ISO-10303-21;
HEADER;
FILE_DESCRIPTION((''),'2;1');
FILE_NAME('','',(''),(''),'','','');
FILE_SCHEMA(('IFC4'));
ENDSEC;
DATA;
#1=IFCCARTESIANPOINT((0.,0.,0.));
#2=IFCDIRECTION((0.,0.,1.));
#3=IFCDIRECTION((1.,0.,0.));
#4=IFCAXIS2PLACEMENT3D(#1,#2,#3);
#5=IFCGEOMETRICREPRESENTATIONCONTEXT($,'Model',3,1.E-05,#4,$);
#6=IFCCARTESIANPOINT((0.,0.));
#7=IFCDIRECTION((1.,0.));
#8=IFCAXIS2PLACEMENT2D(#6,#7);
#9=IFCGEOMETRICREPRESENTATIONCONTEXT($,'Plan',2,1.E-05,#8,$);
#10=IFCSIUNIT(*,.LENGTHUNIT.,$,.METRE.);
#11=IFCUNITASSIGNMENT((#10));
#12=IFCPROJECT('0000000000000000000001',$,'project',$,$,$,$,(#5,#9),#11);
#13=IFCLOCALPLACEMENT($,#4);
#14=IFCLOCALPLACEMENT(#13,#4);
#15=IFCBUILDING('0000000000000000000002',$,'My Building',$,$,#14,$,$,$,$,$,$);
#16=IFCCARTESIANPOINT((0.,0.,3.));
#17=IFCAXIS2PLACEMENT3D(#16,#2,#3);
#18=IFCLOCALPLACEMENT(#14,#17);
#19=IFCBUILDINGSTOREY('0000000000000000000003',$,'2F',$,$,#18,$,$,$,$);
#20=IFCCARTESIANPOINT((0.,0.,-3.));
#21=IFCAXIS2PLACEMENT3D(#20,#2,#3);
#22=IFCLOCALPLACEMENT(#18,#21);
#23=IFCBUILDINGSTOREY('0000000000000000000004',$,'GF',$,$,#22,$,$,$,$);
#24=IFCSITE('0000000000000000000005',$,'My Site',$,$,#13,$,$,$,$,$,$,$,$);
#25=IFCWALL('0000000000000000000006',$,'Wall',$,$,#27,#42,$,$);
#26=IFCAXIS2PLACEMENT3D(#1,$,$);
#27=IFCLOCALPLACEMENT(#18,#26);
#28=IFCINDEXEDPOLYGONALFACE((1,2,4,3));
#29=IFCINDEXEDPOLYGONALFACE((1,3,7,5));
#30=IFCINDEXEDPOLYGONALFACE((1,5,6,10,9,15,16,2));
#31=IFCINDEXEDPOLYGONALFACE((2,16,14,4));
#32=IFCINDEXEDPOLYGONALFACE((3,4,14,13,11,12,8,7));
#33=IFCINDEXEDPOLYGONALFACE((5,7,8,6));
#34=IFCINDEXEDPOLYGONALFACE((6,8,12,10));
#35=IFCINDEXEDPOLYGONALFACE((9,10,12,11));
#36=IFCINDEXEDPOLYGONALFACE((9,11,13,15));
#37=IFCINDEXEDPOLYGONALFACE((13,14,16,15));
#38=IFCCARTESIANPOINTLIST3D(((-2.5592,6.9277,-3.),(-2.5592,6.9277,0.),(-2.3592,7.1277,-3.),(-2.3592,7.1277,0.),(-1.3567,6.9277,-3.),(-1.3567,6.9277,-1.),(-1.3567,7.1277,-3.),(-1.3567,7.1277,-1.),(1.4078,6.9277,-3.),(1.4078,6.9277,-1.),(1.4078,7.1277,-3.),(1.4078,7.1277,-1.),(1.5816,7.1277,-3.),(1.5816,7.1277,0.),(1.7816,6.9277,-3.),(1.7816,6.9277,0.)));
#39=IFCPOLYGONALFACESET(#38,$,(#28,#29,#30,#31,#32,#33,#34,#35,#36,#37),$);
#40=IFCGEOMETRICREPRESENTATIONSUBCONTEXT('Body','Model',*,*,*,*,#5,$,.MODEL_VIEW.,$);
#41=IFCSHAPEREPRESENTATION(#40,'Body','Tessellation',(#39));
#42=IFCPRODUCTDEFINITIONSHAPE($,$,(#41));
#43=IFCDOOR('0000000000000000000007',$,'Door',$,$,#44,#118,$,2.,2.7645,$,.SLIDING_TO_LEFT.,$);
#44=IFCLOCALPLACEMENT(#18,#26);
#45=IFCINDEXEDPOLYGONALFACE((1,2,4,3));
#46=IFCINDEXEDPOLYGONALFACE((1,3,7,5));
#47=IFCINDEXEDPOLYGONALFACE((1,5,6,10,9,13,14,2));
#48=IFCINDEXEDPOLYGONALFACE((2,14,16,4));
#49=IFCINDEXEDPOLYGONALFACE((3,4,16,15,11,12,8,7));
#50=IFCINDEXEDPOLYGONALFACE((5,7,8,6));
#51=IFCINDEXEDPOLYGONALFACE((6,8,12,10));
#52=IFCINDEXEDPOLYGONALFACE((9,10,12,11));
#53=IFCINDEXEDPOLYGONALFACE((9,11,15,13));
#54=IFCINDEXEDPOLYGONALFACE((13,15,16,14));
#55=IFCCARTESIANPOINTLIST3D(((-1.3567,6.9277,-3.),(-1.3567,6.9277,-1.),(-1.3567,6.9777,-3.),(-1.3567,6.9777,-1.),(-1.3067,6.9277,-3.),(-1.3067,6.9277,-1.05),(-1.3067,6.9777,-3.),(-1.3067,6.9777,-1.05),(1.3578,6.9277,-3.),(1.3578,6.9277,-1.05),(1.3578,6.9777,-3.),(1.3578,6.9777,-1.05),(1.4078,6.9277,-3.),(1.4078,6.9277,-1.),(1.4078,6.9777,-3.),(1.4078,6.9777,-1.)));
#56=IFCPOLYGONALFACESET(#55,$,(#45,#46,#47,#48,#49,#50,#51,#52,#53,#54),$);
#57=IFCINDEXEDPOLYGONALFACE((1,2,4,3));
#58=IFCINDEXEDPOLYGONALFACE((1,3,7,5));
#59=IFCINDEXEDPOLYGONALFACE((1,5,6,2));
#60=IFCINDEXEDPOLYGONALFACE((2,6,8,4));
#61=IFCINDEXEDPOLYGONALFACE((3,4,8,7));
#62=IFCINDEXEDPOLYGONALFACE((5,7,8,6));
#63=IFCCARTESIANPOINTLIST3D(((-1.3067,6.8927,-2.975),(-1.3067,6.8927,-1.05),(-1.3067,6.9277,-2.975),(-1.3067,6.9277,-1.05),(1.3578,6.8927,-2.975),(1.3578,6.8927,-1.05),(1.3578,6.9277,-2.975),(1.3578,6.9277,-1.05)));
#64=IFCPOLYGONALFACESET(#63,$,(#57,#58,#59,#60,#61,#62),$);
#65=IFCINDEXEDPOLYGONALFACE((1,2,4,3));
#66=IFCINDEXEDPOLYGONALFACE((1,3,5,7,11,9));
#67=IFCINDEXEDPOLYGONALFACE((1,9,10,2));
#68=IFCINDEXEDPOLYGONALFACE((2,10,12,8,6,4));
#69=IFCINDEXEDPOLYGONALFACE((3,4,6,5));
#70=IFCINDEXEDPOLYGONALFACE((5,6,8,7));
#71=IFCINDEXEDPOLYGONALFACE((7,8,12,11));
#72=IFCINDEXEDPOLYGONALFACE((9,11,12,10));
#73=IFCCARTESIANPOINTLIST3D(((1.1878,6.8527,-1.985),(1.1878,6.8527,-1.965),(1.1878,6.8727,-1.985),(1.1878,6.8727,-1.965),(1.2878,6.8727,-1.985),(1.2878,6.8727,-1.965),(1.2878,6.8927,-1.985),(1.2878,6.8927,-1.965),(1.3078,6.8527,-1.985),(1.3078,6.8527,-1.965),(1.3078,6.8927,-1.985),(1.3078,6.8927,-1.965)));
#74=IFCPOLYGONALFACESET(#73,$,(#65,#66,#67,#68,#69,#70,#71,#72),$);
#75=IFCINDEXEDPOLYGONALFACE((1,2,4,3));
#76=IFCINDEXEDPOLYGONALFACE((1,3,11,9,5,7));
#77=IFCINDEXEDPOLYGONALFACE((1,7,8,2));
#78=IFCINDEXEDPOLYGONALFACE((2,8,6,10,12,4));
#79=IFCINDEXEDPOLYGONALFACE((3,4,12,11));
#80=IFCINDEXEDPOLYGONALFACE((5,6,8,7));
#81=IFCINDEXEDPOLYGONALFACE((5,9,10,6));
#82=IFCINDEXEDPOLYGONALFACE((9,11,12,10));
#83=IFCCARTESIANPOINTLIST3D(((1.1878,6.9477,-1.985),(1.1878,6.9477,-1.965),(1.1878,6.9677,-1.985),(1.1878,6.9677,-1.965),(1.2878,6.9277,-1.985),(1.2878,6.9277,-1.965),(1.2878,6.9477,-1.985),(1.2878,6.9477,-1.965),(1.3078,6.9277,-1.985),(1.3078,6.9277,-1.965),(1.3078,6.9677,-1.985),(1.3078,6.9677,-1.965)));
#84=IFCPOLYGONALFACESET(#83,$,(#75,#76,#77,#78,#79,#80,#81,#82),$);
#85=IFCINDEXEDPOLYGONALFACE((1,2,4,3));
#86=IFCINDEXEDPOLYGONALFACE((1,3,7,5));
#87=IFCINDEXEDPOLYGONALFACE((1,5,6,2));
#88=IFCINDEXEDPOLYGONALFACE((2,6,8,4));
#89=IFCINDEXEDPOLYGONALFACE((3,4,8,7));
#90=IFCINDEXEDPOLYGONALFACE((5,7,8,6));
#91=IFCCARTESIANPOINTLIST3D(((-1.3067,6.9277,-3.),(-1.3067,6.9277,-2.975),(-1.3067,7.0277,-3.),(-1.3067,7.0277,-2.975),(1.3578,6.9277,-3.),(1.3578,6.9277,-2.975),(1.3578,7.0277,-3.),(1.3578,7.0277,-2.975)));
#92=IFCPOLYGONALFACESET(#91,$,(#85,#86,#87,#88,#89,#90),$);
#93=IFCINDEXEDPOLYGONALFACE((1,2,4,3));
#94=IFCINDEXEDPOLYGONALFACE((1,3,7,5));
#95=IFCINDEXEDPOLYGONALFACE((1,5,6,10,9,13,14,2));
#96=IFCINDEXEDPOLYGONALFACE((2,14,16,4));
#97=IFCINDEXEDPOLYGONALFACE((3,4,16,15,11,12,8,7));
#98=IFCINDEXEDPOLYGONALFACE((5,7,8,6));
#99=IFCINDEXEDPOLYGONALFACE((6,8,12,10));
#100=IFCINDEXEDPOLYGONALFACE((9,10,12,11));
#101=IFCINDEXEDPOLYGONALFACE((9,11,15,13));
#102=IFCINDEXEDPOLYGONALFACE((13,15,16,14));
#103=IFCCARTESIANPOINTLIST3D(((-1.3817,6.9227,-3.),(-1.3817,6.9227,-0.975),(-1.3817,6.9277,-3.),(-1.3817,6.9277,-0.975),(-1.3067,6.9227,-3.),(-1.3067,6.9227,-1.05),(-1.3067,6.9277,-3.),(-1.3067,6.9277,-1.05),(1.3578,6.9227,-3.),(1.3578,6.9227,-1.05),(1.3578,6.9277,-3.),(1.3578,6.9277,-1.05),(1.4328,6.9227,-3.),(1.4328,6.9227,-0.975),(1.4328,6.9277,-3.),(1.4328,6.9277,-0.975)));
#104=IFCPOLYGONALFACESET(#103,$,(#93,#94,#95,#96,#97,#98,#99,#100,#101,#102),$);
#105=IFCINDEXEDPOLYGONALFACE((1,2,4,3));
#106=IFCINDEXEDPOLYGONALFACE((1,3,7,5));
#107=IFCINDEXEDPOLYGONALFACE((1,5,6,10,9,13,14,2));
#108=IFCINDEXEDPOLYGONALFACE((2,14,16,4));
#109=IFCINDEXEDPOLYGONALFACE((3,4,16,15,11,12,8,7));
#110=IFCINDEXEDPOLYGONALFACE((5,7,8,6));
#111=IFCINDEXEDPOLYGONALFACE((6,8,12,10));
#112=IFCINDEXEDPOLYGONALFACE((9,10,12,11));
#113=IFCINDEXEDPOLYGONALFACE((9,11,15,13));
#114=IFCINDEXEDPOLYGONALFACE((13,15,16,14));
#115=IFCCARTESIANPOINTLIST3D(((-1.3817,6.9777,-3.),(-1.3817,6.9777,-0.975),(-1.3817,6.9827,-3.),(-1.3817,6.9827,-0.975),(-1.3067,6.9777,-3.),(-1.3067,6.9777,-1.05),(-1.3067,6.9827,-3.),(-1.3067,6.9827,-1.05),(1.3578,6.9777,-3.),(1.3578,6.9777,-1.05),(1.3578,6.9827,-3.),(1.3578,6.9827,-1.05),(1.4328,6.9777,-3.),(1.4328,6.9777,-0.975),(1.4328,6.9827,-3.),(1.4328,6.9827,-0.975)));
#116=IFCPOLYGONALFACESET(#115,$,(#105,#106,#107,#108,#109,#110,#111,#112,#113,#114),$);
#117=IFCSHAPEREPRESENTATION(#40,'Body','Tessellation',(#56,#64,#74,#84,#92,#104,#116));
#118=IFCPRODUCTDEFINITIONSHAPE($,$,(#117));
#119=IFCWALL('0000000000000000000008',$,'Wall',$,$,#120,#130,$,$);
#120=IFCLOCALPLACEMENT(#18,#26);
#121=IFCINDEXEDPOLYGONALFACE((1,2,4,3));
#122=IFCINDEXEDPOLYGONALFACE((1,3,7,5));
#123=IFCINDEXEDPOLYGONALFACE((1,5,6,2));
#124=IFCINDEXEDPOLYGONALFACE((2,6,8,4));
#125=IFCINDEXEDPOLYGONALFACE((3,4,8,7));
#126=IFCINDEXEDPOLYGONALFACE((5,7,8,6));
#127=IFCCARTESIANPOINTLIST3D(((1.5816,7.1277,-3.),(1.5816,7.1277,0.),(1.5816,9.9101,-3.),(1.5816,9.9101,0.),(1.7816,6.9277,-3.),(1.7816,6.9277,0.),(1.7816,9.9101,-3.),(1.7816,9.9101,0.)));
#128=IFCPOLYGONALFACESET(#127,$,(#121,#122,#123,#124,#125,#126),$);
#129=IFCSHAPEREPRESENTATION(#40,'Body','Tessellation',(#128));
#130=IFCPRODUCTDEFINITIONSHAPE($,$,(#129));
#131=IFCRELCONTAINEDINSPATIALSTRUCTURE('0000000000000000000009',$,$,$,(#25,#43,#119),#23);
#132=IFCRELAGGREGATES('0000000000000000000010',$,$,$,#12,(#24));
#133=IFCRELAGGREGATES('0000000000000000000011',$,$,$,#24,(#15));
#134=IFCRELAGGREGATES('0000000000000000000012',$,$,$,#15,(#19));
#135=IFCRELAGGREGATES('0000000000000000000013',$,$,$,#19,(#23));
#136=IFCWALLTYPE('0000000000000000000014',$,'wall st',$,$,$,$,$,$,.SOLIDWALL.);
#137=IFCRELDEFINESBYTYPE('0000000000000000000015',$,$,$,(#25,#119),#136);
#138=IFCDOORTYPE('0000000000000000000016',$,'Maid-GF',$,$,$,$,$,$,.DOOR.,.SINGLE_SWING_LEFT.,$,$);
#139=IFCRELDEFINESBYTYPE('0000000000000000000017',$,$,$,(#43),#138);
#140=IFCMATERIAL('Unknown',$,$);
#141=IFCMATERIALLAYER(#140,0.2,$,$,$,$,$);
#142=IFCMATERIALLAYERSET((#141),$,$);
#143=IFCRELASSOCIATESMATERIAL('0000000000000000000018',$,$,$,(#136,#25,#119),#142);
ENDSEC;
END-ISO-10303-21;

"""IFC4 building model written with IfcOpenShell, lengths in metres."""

from ifc_helpers import new_model, entity, si_unit, frame, origin_with_axes, origin_2d_with_axis, place, context, subcontext, project, spatial, line, indexed_curve, outline, extrude, shape, source, transform, mapped, material, layer, layer_set, layer_usage, type_object, type_shapes, element, fill, save


model = new_model("IFC4")

# Units and contexts
model_context = context("Model", 3, precision=1e-05, world=origin_with_axes())
plan_context = context("Plan", 2, precision=1e-05, world=origin_2d_with_axis())
body_context_1 = subcontext(model_context, "Body", "Model", "MODEL_VIEW")
body_context_2 = subcontext(plan_context, "Body", "Plan", "PLAN_VIEW")
ifc_project = project(units=[si_unit("LENGTHUNIT", "METRE")], contexts=[model_context, plan_context])

# Site, building, storeys
site_placement = place(None, origin_with_axes())
site = spatial("IfcSite", under=ifc_project, at=site_placement, Name="My Site")
building_placement = place(site_placement, origin_with_axes())
building = spatial("IfcBuilding", under=site, at=building_placement, Name="My Building")
storey_1_placement = place(building_placement, frame((0.0, 0.0, 3.0), z_axis=(0.0, 0.0, 1.0), x_axis=(1.0, 0.0, 0.0)))
storey_1 = spatial("IfcBuildingStorey", under=building, at=storey_1_placement, Name="2F")
storey_2_placement = place(storey_1_placement, frame((0.0, 0.0, -3.0), z_axis=(0.0, 0.0, 1.0), x_axis=(1.0, 0.0, 0.0)))
storey_2 = spatial("IfcBuildingStorey", under=storey_1, at=storey_2_placement, Name="GF")

# Shared definitions
ifc_material = material(Name="Unknown")

# Shared definitions
ifc_layer = layer(ifc_material, 0.2)
ifc_layer_set = layer_set([ifc_layer])
wall_type = type_object("IfcWallType", Name="wall st", PredefinedType="SOLIDWALL", material=ifc_layer_set)

# Wall, opening, door
ifc_layer_usage_1 = layer_usage(ifc_layer_set, "AXIS2", "POSITIVE", 0.0)
wall_1_placement = place(storey_2_placement, frame((-2.5592, 6.9277, 0.0), z_axis=(0.0, 0.0, 1.0), x_axis=(1.0, 0.0, 0.0)))
wall_1 = element("IfcWall", 1, at=wall_1_placement, inside=storey_2, type_object=wall_type, material=ifc_layer_usage_1, Name="Wall", context=body_context_1, shape_type="SweptSolid", body=[
    extrude(outline(indexed_curve([(0.0, 0.0), (0.2, 0.2), (4.1408, 0.2), (4.3408, 0.0)], segments=[line(1, 2, 3, 4, 1)])), origin_with_axes(), (0.0, 0.0, 1.0), 3.0),
])
shared_shape_1 = source(origin_with_axes(), body_context_1, "Body", "SweptSolid", [
    extrude(outline(indexed_curve([(0.0, 0.0), (2.7645, 0.0), (2.7645, 2.0), (0.0, 2.0)], segments=[line(1, 2, 3, 4, 1)])), frame((0.0, -0.6, 0.0), z_axis=(0.0, -1.0, 0.0), x_axis=(1.0, 0.0, 0.0)), (0.0, 0.0, -1.0), 1.2),
])
opening_1_placement = place(wall_1_placement, frame((1.2026, 0.0, 0.0), z_axis=(0.0, 0.0, 1.0), x_axis=(1.0, 0.0, 0.0)))
opening_1 = element("IfcOpeningElement", 2, at=opening_1_placement, cuts=wall_1, PredefinedType="OPENING", context=body_context_1, shape_type="MappedRepresentation", body=[
    mapped(shared_shape_1, transform((0.0, 0.0, 0.0), x_axis=(1.0, 0.0, 0.0), y_axis=(0.0, 1.0, 0.0), z_axis=(0.0, 0.0, 1.0), scale=1.0)),
])
door_type_1 = type_object("IfcDoorType", Name="Maid-GF", OperationType="SINGLE_SWING_LEFT", PredefinedType="DOOR")
shared_shape_2 = source(origin_with_axes(), body_context_1, "Body", "SweptSolid", [
    extrude(outline(indexed_curve([(0.0, 0.0), (0.0, 2.0), (2.7645, 2.0), (2.7645, 0.0), (2.7145, 0.0), (2.7145, 1.95), (0.05, 1.95), (0.05, 0.0)], segments=[line(1, 2, 3, 4, 5, 6, 7, 8, 1)])), frame((0.0, 0.0, 0.0), z_axis=(0.0, -1.0, 0.0), x_axis=(1.0, 0.0, 0.0)), (0.0, 0.0, -1.0), 0.05),
    extrude(outline(indexed_curve([(0.0, 0.0), (2.6645, 0.0), (2.6645, 0.035), (0.0, 0.035)], segments=[line(1, 2, 3, 4, 1)])), frame((0.05, -0.035, 0.025), z_axis=(0.0, 0.0, 1.0), x_axis=(1.0, 0.0, 0.0)), (0.0, 0.0, 1.0), 1.925),
    extrude(outline(indexed_curve([(0.0, 0.0), (0.0, -0.04), (-0.12, -0.04), (-0.12, -0.02), (-0.02, -0.02), (-0.02, 0.0)], segments=[line(1, 2, 3, 4, 5, 6, 1)])), frame((2.6645, -0.035, 1.015), z_axis=(0.0, 0.0, 1.0), x_axis=(1.0, 0.0, 0.0)), (0.0, 0.0, 1.0), 0.02),
    extrude(outline(indexed_curve([(0.0, 0.0), (0.0, 0.04), (-0.12, 0.04), (-0.12, 0.02), (-0.02, 0.02), (-0.02, 0.0)], segments=[line(1, 2, 3, 4, 5, 6, 1)])), frame((2.6645, 0.0, 1.015), z_axis=(0.0, 0.0, 1.0), x_axis=(1.0, 0.0, 0.0)), (0.0, 0.0, 1.0), 0.02),
    extrude(outline(indexed_curve([(0.0, 0.0), (2.6645, 0.0), (2.6645, 0.1), (0.0, 0.1)], segments=[line(1, 2, 3, 4, 1)])), frame((0.05, 0.0, 0.0), z_axis=(0.0, 0.0, 1.0), x_axis=(1.0, 0.0, 0.0)), (0.0, 0.0, 1.0), 0.025),
    extrude(outline(indexed_curve([(0.0, 0.0), (0.0, 2.025), (2.8145, 2.025), (2.8145, 0.0), (2.7395, 0.0), (2.7395, 1.95), (0.075, 1.95), (0.075, 0.0)], segments=[line(1, 2, 3, 4, 5, 6, 7, 8, 1)])), frame((-0.025, -0.005, 0.0), z_axis=(0.0, -1.0, 0.0), x_axis=(1.0, 0.0, 0.0)), (0.0, 0.0, -1.0), 0.005),
    extrude(outline(indexed_curve([(0.0, 0.0), (0.0, 2.025), (2.8145, 2.025), (2.8145, 0.0), (2.7395, 0.0), (2.7395, 1.95), (0.075, 1.95), (0.075, 0.0)], segments=[line(1, 2, 3, 4, 5, 6, 7, 8, 1)])), frame((-0.025, 0.05, 0.0), z_axis=(0.0, -1.0, 0.0), x_axis=(1.0, 0.0, 0.0)), (0.0, 0.0, -1.0), 0.005),
])
shared_shape_3 = source(origin_with_axes(), body_context_2, "Body", "Curve2D", [
    entity("IfcIndexedPolyCurve", entity("IfcCartesianPointList2D", [[0.0, 0.0], [0.05, 0.0], [0.05, 0.05], [0.0, 0.05]]), [entity("IfcLineIndex", [1, 2, 3, 4, 1])]),
    entity("IfcIndexedPolyCurve", entity("IfcCartesianPointList2D", [[2.7645, 0.0], [2.7145, 0.0], [2.7145, 0.05], [2.7645, 0.05]]), [entity("IfcLineIndex", [1, 2, 3, 4, 1])]),
    entity("IfcIndexedPolyCurve", entity("IfcCartesianPointList2D", [[-1.2823, -0.035], [1.3823, -0.035], [1.3823, 0.0], [-1.2823, 0.0]]), [entity("IfcLineIndex", [1, 2, 3, 4, 1])]),
])
type_shapes(door_type_1, [shared_shape_2, shared_shape_3])
door_1_placement = place(opening_1_placement, origin_with_axes())
door_1 = element("IfcDoor", 3, at=door_1_placement, inside=storey_2, type_object=door_type_1, Name="Door", OperationType="SLIDING_TO_LEFT", OverallHeight=2.0, OverallWidth=2.7645, shapes=[
    shape(body_context_1, "Body", "MappedRepresentation", [mapped(shared_shape_2, transform((0.0, 0.0, 0.0), x_axis=(1.0, 0.0, 0.0), y_axis=(0.0, 1.0, 0.0), z_axis=(0.0, 0.0, 1.0), scale=1.0))]),
    shape(body_context_2, "Body", "MappedRepresentation", [mapped(shared_shape_3, transform((0.0, 0.0, 0.0), x_axis=(1.0, 0.0, 0.0), y_axis=(0.0, 1.0, 0.0), z_axis=(0.0, 0.0, 1.0), scale=1.0))]),
])
fill(opening_1, door_1)

# Wall
ifc_layer_usage_2 = layer_usage(ifc_layer_set, "AXIS2", "POSITIVE", 0.0)
wall_2_placement = place(storey_2_placement, frame((1.7816, 6.9277, 0.0), z_axis=(0.0, 0.0, 1.0), x_axis=(0.0, 1.0, 0.0)))
element("IfcWall", 4, at=wall_2_placement, inside=storey_2, type_object=wall_type, material=ifc_layer_usage_2, Name="Wall", context=body_context_1, shape_type="SweptSolid", body=[
    extrude(outline(indexed_curve([(0.0, 0.0), (0.2, 0.2), (2.9823, 0.2), (2.9823, 0.0)], segments=[line(1, 2, 3, 4, 1)])), origin_with_axes(), (0.0, 0.0, 1.0), 3.0),
])

save(model, "model.ifc")
